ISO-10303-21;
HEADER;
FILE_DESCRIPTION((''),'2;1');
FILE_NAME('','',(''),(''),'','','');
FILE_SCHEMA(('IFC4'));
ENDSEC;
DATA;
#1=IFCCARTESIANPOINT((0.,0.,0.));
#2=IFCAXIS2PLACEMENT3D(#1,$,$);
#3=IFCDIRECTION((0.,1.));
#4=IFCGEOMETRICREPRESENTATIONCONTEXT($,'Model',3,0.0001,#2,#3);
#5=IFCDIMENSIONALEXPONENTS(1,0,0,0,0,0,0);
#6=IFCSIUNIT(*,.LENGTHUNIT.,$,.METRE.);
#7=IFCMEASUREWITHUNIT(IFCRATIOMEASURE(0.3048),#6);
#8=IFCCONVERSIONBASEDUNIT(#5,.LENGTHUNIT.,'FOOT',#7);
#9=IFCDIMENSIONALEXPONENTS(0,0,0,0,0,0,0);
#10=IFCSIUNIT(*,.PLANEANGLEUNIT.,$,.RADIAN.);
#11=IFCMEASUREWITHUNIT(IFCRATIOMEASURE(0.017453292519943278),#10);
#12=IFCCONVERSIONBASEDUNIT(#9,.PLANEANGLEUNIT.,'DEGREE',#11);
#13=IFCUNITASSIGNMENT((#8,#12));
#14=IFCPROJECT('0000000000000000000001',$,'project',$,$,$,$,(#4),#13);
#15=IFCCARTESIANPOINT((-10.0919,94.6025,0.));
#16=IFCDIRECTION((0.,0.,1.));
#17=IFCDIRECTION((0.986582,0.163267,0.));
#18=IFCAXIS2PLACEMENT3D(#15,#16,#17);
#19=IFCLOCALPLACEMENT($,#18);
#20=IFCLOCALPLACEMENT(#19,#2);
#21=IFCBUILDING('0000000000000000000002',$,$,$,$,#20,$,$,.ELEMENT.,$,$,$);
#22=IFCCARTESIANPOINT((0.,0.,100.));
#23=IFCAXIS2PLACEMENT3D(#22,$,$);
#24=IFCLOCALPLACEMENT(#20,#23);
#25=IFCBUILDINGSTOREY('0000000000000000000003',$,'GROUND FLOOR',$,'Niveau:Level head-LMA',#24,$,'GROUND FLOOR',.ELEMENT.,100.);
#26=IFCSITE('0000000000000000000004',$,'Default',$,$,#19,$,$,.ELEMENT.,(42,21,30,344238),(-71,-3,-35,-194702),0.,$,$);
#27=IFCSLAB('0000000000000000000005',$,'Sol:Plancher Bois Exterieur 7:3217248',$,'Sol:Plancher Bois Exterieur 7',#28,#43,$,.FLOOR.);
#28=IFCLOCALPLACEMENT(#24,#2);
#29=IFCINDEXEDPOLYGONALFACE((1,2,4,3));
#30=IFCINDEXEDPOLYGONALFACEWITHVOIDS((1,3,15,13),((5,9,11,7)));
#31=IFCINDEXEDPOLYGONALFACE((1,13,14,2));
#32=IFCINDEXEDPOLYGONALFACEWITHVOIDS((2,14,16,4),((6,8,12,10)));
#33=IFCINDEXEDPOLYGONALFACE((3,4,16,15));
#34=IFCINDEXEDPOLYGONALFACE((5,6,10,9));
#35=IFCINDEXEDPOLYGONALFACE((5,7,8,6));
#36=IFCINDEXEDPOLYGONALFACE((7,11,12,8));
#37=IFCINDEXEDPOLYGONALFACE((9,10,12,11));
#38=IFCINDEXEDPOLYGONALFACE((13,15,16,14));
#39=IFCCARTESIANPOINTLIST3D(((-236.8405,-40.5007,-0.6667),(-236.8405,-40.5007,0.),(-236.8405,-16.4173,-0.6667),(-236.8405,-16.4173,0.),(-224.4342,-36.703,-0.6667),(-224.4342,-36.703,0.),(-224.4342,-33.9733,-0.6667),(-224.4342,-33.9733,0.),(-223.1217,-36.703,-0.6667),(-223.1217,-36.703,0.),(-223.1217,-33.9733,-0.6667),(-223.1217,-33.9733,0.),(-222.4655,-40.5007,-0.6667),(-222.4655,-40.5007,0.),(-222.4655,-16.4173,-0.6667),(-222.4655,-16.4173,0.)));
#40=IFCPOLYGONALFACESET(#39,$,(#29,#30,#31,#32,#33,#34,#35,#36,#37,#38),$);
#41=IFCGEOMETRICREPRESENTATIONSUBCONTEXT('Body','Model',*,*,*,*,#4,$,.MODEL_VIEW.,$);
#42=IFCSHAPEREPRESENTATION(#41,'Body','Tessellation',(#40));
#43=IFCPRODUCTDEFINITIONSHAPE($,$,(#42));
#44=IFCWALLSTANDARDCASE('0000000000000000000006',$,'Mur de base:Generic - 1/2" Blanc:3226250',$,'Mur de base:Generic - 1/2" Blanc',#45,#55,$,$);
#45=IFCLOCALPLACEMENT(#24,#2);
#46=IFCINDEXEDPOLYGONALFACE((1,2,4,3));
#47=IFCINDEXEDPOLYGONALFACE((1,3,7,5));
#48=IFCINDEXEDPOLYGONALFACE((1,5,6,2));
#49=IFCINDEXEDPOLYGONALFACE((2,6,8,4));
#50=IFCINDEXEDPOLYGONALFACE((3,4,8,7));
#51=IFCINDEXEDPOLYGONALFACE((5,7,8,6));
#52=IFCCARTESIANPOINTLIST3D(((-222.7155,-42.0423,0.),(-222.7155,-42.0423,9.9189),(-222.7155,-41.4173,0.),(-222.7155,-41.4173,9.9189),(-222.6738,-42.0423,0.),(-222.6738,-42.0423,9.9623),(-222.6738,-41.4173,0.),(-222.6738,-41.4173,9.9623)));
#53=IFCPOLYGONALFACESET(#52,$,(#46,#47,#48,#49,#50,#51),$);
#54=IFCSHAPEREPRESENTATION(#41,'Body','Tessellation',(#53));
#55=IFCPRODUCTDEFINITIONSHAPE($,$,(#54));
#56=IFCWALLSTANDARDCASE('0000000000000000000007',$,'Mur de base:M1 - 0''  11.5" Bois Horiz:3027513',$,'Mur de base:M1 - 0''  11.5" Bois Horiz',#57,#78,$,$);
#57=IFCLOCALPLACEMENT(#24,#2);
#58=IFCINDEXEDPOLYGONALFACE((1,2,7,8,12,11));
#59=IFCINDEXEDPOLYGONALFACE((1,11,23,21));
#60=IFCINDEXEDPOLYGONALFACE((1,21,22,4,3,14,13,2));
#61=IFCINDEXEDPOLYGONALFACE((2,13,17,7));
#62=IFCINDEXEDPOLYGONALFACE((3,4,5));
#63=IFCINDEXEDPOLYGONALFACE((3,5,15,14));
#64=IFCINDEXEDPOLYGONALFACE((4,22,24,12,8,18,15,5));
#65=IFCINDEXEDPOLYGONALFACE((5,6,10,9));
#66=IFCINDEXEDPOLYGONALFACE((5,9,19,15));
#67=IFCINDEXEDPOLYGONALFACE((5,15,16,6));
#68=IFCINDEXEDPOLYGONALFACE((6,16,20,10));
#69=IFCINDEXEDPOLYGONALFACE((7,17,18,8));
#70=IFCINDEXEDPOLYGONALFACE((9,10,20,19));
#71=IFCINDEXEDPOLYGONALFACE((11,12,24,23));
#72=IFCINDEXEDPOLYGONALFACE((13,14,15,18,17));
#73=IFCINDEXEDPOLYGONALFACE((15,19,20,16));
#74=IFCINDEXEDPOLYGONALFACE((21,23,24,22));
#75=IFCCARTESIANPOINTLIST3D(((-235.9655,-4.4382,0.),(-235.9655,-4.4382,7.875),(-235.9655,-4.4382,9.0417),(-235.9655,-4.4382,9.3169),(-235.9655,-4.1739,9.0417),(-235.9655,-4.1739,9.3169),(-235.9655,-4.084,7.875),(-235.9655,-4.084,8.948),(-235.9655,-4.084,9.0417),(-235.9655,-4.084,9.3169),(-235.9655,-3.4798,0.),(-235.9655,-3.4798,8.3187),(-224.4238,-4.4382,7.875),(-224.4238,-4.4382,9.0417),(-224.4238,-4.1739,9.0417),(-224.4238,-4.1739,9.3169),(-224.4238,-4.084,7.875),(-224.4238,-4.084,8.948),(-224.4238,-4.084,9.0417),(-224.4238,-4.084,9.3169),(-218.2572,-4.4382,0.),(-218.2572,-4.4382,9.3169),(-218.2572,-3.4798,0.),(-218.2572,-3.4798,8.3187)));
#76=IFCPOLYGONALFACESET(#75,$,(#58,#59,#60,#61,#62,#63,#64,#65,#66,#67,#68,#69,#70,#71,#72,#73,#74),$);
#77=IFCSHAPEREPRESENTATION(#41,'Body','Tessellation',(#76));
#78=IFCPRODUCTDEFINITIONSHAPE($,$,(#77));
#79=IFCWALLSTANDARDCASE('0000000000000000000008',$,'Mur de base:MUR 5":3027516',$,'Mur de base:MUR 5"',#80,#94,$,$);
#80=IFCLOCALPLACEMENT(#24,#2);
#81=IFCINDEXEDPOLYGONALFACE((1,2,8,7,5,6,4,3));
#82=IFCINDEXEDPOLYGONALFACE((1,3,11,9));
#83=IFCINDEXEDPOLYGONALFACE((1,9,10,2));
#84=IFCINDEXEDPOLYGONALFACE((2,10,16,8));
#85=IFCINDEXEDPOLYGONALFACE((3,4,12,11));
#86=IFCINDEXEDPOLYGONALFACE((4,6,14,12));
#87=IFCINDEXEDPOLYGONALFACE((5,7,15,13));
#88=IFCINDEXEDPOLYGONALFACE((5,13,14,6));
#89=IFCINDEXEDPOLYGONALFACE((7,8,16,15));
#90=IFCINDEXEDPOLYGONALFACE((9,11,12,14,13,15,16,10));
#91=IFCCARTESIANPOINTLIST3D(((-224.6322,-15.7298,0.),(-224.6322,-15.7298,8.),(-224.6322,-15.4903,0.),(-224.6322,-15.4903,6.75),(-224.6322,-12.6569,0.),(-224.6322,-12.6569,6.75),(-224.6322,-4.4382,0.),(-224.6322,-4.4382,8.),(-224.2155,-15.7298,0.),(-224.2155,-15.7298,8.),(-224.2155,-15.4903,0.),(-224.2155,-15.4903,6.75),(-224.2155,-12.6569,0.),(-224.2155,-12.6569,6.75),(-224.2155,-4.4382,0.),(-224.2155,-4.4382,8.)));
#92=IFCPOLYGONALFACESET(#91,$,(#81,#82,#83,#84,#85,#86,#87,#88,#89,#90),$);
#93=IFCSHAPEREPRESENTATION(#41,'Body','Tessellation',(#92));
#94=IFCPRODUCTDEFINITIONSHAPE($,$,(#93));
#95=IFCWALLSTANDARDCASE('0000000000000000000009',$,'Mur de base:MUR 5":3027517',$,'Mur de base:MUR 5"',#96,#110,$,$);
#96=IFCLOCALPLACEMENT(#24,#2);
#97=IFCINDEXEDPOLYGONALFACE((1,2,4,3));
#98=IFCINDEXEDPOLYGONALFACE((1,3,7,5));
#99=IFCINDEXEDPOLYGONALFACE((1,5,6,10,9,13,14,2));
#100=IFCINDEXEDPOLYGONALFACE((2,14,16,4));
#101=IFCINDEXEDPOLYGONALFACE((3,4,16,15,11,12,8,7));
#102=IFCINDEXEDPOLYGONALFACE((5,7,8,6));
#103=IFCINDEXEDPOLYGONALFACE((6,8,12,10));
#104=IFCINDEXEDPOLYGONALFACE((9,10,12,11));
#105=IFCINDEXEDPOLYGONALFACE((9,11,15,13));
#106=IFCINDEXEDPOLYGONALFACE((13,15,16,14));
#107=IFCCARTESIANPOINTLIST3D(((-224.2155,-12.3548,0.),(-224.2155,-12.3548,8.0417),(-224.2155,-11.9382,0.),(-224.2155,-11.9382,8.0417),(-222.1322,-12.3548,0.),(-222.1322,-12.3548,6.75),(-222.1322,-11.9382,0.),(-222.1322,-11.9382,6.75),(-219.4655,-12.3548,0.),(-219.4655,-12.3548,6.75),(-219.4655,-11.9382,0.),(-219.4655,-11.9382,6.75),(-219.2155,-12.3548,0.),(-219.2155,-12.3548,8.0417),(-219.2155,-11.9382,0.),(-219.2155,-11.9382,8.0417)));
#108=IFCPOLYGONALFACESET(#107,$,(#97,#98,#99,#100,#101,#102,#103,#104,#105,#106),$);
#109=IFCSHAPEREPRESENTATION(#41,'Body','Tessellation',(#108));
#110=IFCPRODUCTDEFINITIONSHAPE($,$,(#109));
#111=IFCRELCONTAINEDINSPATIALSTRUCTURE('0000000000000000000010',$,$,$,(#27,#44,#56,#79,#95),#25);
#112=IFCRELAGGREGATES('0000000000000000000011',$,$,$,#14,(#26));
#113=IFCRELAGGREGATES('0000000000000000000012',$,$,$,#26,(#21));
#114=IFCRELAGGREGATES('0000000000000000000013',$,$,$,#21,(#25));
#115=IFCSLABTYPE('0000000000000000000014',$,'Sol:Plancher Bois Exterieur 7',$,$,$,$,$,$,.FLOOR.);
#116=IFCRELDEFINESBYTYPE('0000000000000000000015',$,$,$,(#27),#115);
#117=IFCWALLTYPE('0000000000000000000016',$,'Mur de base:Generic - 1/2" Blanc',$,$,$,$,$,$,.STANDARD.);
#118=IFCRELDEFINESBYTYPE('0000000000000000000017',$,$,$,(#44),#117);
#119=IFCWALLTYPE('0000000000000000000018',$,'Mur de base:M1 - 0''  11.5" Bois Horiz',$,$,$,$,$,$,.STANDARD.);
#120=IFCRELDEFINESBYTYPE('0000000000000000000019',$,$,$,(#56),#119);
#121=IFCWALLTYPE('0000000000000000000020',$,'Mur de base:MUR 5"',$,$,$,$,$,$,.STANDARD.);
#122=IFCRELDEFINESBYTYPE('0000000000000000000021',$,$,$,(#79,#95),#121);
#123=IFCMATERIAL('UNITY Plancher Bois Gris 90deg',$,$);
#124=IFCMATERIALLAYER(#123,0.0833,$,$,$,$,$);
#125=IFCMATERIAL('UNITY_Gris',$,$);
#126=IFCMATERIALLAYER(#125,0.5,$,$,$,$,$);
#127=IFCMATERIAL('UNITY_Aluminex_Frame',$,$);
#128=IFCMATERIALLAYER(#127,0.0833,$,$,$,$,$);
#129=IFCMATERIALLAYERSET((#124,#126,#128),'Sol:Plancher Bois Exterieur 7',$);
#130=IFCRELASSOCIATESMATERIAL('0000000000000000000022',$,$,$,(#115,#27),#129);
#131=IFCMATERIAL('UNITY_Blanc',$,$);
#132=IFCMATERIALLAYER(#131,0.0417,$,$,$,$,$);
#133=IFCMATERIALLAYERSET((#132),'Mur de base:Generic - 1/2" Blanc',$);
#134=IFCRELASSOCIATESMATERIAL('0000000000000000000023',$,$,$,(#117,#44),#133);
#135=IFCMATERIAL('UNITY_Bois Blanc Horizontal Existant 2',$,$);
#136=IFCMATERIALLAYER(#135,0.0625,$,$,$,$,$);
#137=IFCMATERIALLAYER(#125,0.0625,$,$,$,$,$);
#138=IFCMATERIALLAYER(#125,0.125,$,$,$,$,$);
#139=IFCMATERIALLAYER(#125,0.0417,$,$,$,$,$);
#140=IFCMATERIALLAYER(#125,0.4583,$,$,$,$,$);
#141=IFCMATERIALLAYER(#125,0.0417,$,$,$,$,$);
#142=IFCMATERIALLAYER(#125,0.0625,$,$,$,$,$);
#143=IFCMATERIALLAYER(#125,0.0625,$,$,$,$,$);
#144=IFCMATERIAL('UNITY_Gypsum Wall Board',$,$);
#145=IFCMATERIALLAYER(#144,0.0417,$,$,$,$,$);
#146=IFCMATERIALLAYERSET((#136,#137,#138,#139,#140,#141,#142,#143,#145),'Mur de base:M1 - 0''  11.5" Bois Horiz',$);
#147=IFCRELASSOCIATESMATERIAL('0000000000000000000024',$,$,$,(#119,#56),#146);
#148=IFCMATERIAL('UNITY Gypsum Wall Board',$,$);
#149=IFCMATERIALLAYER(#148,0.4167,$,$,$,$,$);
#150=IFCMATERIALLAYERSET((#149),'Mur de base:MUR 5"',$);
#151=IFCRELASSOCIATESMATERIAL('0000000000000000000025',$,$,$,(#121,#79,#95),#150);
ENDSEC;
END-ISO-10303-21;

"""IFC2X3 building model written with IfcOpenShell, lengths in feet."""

from ifc_helpers import new_model, entity, si_unit, converted_unit, direction, frame, frame_2d, origin, origin_2d_with_axis, place, context, subcontext, project, spatial, polyline, rectangle, extrude, clip, bounded_halfspace, material, layer, layer_set, layer_usage, type_object, element, save


model = new_model("IFC2X3")

# Units and contexts
model_context = context("Model", 3, precision=0.0001, world=origin(), true_north=direction((0.0, 1.0)))
body_context = subcontext(model_context, "Body", "Model", "MODEL_VIEW")
ifc_project = project(units=[converted_unit("LENGTHUNIT", "FOOT", entity("IfcRatioMeasure", 0.3048), si_unit("LENGTHUNIT", "METRE"), dimensions=[1, 0, 0, 0, 0, 0, 0]), converted_unit("PLANEANGLEUNIT", "DEGREE", entity("IfcRatioMeasure", 0.017453292519943278), si_unit("PLANEANGLEUNIT", "RADIAN"), dimensions=[0, 0, 0, 0, 0, 0, 0])], contexts=[model_context])

# Site, building, storey
site_placement = place(None, frame((-10.0919, 94.6025, 0.0), z_axis=(0.0, 0.0, 1.0), x_axis=(0.986582, 0.163267, 0.0)))
site = spatial("IfcSite", under=ifc_project, at=site_placement, Name="Default", CompositionType="ELEMENT", RefLatitude=(42, 21, 30, 344238), RefLongitude=(-71, -3, -35, -194702), RefElevation=0.0)
building_placement = place(site_placement, origin())
building = spatial("IfcBuilding", under=site, at=building_placement, CompositionType="ELEMENT")
storey_placement = place(building_placement, frame((0.0, 0.0, 100.0)))
storey = spatial("IfcBuildingStorey", under=building, at=storey_placement, Name="GROUND FLOOR", ObjectType="Niveau:Level head-LMA", LongName="GROUND FLOOR", CompositionType="ELEMENT", Elevation=100.0)

# Shared definitions
ifc_material_1 = material(Name="UNITY_Aluminex_Frame")

# Slab, opening
ifc_material_2 = material(Name="UNITY Plancher Bois Gris 90deg")
ifc_layer_1 = layer(ifc_material_2, 0.0833)
ifc_material_3 = material(Name="UNITY_Gris")
ifc_layer_2 = layer(ifc_material_3, 0.5)
ifc_layer_3 = layer(ifc_material_1, 0.0833)
ifc_layer_set_1 = layer_set([ifc_layer_1, ifc_layer_2, ifc_layer_3], Name="Sol:Plancher Bois Exterieur 7")
ifc_layer_usage_1 = layer_usage(ifc_layer_set_1, "AXIS3", "POSITIVE", 0.0)
slab_type = type_object("IfcSlabType", Name="Sol:Plancher Bois Exterieur 7", PredefinedType="FLOOR", material=ifc_layer_set_1)
slab_placement = place(storey_placement, frame((-236.8405, -40.5007, -0.6667)))
slab = element("IfcSlab", 1, at=slab_placement, inside=storey, type_object=slab_type, material=ifc_layer_usage_1, Name="Sol:Plancher Bois Exterieur 7:3217248", ObjectType="Sol:Plancher Bois Exterieur 7", PredefinedType="FLOOR", context=body_context, shape_type="SweptSolid", body=[
    extrude(rectangle(XDim=24.0833, YDim=14.375, at=frame_2d((0.0, 0.0), x_axis=(0.0, 1.0))), frame((7.1875, 12.0417, 0.6667), z_axis=(0.0, 0.0, -1.0), x_axis=(-1.0, 0.0, 0.0)), (0.0, 0.0, 1.0), 0.6667),
])
opening_1_placement = place(slab_placement, frame((13.0625, 5.1625, 0.6667)))
element("IfcOpeningElement", 2, at=opening_1_placement, cuts=slab, ObjectType="Opening", context=body_context, shape_type="SweptSolid", body=[
    extrude(rectangle(XDim=2.7297, YDim=1.3125, at=origin_2d_with_axis()), frame((0.0, 0.0, 0.0), z_axis=(0.0, 0.0, -1.0), x_axis=(0.0, 1.0, 0.0)), (0.0, 0.0, 1.0), 0.6667),
])

# Wall
ifc_material_4 = material(Name="UNITY_Blanc")
ifc_layer_4 = layer(ifc_material_4, 0.0417)
ifc_layer_set_2 = layer_set([ifc_layer_4], Name="Mur de base:Generic - 1/2\" Blanc")
ifc_layer_usage_2 = layer_usage(ifc_layer_set_2, "AXIS2", "POSITIVE", -0.0208)
wall_type_1 = type_object("IfcWallType", Name="Mur de base:Generic - 1/2\" Blanc", PredefinedType="STANDARD", material=ifc_layer_set_2)
wall_1_placement = place(storey_placement, frame((-222.6947, -41.4173, 0.0), z_axis=(0.0, 0.0, 1.0), x_axis=(0.0, -1.0, 0.0)))
element("IfcWallStandardCase", 3, at=wall_1_placement, inside=storey, type_object=wall_type_1, material=ifc_layer_usage_2, Name="Mur de base:Generic - 1/2\" Blanc:3226250", ObjectType="Mur de base:Generic - 1/2\" Blanc", context=body_context, shape_type="Clipping", body=[
    clip(extrude(rectangle(XDim=0.625, YDim=0.0417, at=frame_2d((0.3125, 0.0), x_axis=(-1.0, 0.0))), origin(), (0.0, 0.0, 1.0), 9.9623), bounded_halfspace(frame((0.0, -0.0208, 9.9189), z_axis=(0.0, -0.721387, 0.692532), x_axis=(1.0, 0.0, 0.0)), False, frame((0.0, -0.0208, 9.9189)), polyline([(0.0, 0.0), (0.625, 0.0), (0.625, 0.0417), (0.0, 0.0417), (0.0, 0.0)]))),
])

# Shared definitions
ifc_material_5 = material(Name="UNITY_Bois Blanc Horizontal Existant 2")
ifc_layer_5 = layer(ifc_material_5, 0.0625)
ifc_layer_6 = layer(ifc_material_3, 0.0625)
ifc_layer_7 = layer(ifc_material_3, 0.125)
ifc_layer_8 = layer(ifc_material_3, 0.0417)
ifc_layer_9 = layer(ifc_material_3, 0.4583)
ifc_layer_10 = layer(ifc_material_3, 0.0417)
ifc_layer_11 = layer(ifc_material_3, 0.0625)
ifc_layer_12 = layer(ifc_material_3, 0.0625)
ifc_material_6 = material(Name="UNITY_Gypsum Wall Board")
ifc_layer_13 = layer(ifc_material_6, 0.0417)
ifc_layer_set_3 = layer_set([ifc_layer_5, ifc_layer_6, ifc_layer_7, ifc_layer_8, ifc_layer_9, ifc_layer_10, ifc_layer_11, ifc_layer_12, ifc_layer_13], Name="Mur de base:M1 - 0'  11.5\" Bois Horiz")
wall_type_2 = type_object("IfcWallType", Name="Mur de base:M1 - 0'  11.5\" Bois Horiz", PredefinedType="STANDARD", material=ifc_layer_set_3)

# Walls, openings
ifc_layer_usage_3 = layer_usage(ifc_layer_set_3, "AXIS2", "NEGATIVE", 0.4792)
wall_2_placement = place(storey_placement, frame((-235.9655, -3.959, 0.0)))
wall_2 = element("IfcWallStandardCase", 4, at=wall_2_placement, inside=storey, type_object=wall_type_2, material=ifc_layer_usage_3, Name="Mur de base:M1 - 0'  11.5\" Bois Horiz:3027513", ObjectType="Mur de base:M1 - 0'  11.5\" Bois Horiz", context=body_context, shape_type="Clipping", body=[
    clip(extrude(rectangle(XDim=17.7083, YDim=0.9583, at=frame_2d((8.8542, 0.0), x_axis=(-1.0, 0.0))), origin(), (0.0, 0.0, 1.0), 9.3169), bounded_halfspace(frame((0.0, -0.4792, 9.3169), z_axis=(0.0, 0.721387, 0.692532), x_axis=(-1.0, 0.0, 0.0)), False, frame((0.0, -0.4792, 9.3169)), polyline([(0.0, 0.0), (11.3333, 0.0), (11.75, 0.0), (16.75, 0.0), (17.7083, 0.0), (17.7083, 0.9583), (0.0, 0.9583), (0.0, 0.3542), (11.5417, 0.3542), (11.5417, 0.2643), (0.0, 0.2643), (0.0, 0.0)]))),
])
opening_2_placement = place(storey_placement, frame((-235.9655, -3.959, 0.0)))
element("IfcOpeningElement", 5, at=opening_2_placement, cuts=wall_2, ObjectType="Opening", context=body_context, shape_type="SweptSolid", body=[
    extrude(rectangle(XDim=0.3542, YDim=11.5417, at=frame_2d((0.0, 0.0), x_axis=(1.0, 0.0))), frame((5.7708, -0.3021, 7.875), z_axis=(0.0, 0.0, 1.0), x_axis=(0.0, 1.0, 0.0)), (0.0, 0.0, 1.0), 1.1667),
])
ifc_material_7 = material(Name="UNITY Gypsum Wall Board")
ifc_layer_14 = layer(ifc_material_7, 0.4167)
ifc_layer_set_4 = layer_set([ifc_layer_14], Name="Mur de base:MUR 5\"")
ifc_layer_usage_4 = layer_usage(ifc_layer_set_4, "AXIS2", "NEGATIVE", 0.2083)
wall_type_3 = type_object("IfcWallType", Name="Mur de base:MUR 5\"", PredefinedType="STANDARD", material=ifc_layer_set_4)
wall_3_placement = place(storey_placement, frame((-224.4238, -15.7298, 0.0), z_axis=(0.0, 0.0, 1.0), x_axis=(0.0, 1.0, 0.0)))
wall_3 = element("IfcWallStandardCase", 6, at=wall_3_placement, inside=storey, type_object=wall_type_3, material=ifc_layer_usage_4, Name="Mur de base:MUR 5\":3027516", ObjectType="Mur de base:MUR 5\"", context=body_context, shape_type="SweptSolid", body=[
    extrude(rectangle(XDim=11.2917, YDim=0.4167, at=frame_2d((5.6458, 0.0), x_axis=(-1.0, 0.0))), origin(), (0.0, 0.0, 1.0), 8.0),
])
opening_3_placement = place(wall_3_placement, frame((15.7298, -224.4238, 0.0), z_axis=(0.0, 0.0, 1.0), x_axis=(0.0, -1.0, 0.0)))
element("IfcOpeningElement", 7, at=opening_3_placement, cuts=wall_3, ObjectType="Opening", context=body_context, shape_type="SweptSolid", body=[
    extrude(rectangle(XDim=6.75, YDim=2.8333, at=frame_2d((0.0, 0.0), x_axis=(1.0, 0.0))), frame((-219.2155, -14.0736, 3.375), z_axis=(-1.0, 0.0, 0.0), x_axis=(0.0, 0.0, 1.0)), (0.0, 0.0, 1.0), 10.0),
])
ifc_layer_usage_5 = layer_usage(ifc_layer_set_4, "AXIS2", "POSITIVE", -0.2083)
wall_4_placement = place(storey_placement, frame((-224.2155, -12.1465, 0.0)))
wall_4 = element("IfcWallStandardCase", 8, at=wall_4_placement, inside=storey, type_object=wall_type_3, material=ifc_layer_usage_5, Name="Mur de base:MUR 5\":3027517", ObjectType="Mur de base:MUR 5\"", context=body_context, shape_type="SweptSolid", body=[
    extrude(rectangle(XDim=5.0, YDim=0.4167, at=frame_2d((2.5, 0.0), x_axis=(-1.0, 0.0))), origin(), (0.0, 0.0, 1.0), 8.0417),
])
opening_4_placement = place(wall_4_placement, frame((224.2155, 12.1465, 0.0)))
element("IfcOpeningElement", 9, at=opening_4_placement, cuts=wall_4, ObjectType="Opening", context=body_context, shape_type="SweptSolid", body=[
    extrude(rectangle(XDim=6.75, YDim=2.6667, at=frame_2d((0.0, 0.0), x_axis=(0.0, 1.0))), frame((-220.7988, -17.3548, 3.375), z_axis=(0.0, 1.0, 0.0), x_axis=(-1.0, 0.0, 0.0)), (0.0, 0.0, 1.0), 10.0),
])

save(model, "model.ifc")
